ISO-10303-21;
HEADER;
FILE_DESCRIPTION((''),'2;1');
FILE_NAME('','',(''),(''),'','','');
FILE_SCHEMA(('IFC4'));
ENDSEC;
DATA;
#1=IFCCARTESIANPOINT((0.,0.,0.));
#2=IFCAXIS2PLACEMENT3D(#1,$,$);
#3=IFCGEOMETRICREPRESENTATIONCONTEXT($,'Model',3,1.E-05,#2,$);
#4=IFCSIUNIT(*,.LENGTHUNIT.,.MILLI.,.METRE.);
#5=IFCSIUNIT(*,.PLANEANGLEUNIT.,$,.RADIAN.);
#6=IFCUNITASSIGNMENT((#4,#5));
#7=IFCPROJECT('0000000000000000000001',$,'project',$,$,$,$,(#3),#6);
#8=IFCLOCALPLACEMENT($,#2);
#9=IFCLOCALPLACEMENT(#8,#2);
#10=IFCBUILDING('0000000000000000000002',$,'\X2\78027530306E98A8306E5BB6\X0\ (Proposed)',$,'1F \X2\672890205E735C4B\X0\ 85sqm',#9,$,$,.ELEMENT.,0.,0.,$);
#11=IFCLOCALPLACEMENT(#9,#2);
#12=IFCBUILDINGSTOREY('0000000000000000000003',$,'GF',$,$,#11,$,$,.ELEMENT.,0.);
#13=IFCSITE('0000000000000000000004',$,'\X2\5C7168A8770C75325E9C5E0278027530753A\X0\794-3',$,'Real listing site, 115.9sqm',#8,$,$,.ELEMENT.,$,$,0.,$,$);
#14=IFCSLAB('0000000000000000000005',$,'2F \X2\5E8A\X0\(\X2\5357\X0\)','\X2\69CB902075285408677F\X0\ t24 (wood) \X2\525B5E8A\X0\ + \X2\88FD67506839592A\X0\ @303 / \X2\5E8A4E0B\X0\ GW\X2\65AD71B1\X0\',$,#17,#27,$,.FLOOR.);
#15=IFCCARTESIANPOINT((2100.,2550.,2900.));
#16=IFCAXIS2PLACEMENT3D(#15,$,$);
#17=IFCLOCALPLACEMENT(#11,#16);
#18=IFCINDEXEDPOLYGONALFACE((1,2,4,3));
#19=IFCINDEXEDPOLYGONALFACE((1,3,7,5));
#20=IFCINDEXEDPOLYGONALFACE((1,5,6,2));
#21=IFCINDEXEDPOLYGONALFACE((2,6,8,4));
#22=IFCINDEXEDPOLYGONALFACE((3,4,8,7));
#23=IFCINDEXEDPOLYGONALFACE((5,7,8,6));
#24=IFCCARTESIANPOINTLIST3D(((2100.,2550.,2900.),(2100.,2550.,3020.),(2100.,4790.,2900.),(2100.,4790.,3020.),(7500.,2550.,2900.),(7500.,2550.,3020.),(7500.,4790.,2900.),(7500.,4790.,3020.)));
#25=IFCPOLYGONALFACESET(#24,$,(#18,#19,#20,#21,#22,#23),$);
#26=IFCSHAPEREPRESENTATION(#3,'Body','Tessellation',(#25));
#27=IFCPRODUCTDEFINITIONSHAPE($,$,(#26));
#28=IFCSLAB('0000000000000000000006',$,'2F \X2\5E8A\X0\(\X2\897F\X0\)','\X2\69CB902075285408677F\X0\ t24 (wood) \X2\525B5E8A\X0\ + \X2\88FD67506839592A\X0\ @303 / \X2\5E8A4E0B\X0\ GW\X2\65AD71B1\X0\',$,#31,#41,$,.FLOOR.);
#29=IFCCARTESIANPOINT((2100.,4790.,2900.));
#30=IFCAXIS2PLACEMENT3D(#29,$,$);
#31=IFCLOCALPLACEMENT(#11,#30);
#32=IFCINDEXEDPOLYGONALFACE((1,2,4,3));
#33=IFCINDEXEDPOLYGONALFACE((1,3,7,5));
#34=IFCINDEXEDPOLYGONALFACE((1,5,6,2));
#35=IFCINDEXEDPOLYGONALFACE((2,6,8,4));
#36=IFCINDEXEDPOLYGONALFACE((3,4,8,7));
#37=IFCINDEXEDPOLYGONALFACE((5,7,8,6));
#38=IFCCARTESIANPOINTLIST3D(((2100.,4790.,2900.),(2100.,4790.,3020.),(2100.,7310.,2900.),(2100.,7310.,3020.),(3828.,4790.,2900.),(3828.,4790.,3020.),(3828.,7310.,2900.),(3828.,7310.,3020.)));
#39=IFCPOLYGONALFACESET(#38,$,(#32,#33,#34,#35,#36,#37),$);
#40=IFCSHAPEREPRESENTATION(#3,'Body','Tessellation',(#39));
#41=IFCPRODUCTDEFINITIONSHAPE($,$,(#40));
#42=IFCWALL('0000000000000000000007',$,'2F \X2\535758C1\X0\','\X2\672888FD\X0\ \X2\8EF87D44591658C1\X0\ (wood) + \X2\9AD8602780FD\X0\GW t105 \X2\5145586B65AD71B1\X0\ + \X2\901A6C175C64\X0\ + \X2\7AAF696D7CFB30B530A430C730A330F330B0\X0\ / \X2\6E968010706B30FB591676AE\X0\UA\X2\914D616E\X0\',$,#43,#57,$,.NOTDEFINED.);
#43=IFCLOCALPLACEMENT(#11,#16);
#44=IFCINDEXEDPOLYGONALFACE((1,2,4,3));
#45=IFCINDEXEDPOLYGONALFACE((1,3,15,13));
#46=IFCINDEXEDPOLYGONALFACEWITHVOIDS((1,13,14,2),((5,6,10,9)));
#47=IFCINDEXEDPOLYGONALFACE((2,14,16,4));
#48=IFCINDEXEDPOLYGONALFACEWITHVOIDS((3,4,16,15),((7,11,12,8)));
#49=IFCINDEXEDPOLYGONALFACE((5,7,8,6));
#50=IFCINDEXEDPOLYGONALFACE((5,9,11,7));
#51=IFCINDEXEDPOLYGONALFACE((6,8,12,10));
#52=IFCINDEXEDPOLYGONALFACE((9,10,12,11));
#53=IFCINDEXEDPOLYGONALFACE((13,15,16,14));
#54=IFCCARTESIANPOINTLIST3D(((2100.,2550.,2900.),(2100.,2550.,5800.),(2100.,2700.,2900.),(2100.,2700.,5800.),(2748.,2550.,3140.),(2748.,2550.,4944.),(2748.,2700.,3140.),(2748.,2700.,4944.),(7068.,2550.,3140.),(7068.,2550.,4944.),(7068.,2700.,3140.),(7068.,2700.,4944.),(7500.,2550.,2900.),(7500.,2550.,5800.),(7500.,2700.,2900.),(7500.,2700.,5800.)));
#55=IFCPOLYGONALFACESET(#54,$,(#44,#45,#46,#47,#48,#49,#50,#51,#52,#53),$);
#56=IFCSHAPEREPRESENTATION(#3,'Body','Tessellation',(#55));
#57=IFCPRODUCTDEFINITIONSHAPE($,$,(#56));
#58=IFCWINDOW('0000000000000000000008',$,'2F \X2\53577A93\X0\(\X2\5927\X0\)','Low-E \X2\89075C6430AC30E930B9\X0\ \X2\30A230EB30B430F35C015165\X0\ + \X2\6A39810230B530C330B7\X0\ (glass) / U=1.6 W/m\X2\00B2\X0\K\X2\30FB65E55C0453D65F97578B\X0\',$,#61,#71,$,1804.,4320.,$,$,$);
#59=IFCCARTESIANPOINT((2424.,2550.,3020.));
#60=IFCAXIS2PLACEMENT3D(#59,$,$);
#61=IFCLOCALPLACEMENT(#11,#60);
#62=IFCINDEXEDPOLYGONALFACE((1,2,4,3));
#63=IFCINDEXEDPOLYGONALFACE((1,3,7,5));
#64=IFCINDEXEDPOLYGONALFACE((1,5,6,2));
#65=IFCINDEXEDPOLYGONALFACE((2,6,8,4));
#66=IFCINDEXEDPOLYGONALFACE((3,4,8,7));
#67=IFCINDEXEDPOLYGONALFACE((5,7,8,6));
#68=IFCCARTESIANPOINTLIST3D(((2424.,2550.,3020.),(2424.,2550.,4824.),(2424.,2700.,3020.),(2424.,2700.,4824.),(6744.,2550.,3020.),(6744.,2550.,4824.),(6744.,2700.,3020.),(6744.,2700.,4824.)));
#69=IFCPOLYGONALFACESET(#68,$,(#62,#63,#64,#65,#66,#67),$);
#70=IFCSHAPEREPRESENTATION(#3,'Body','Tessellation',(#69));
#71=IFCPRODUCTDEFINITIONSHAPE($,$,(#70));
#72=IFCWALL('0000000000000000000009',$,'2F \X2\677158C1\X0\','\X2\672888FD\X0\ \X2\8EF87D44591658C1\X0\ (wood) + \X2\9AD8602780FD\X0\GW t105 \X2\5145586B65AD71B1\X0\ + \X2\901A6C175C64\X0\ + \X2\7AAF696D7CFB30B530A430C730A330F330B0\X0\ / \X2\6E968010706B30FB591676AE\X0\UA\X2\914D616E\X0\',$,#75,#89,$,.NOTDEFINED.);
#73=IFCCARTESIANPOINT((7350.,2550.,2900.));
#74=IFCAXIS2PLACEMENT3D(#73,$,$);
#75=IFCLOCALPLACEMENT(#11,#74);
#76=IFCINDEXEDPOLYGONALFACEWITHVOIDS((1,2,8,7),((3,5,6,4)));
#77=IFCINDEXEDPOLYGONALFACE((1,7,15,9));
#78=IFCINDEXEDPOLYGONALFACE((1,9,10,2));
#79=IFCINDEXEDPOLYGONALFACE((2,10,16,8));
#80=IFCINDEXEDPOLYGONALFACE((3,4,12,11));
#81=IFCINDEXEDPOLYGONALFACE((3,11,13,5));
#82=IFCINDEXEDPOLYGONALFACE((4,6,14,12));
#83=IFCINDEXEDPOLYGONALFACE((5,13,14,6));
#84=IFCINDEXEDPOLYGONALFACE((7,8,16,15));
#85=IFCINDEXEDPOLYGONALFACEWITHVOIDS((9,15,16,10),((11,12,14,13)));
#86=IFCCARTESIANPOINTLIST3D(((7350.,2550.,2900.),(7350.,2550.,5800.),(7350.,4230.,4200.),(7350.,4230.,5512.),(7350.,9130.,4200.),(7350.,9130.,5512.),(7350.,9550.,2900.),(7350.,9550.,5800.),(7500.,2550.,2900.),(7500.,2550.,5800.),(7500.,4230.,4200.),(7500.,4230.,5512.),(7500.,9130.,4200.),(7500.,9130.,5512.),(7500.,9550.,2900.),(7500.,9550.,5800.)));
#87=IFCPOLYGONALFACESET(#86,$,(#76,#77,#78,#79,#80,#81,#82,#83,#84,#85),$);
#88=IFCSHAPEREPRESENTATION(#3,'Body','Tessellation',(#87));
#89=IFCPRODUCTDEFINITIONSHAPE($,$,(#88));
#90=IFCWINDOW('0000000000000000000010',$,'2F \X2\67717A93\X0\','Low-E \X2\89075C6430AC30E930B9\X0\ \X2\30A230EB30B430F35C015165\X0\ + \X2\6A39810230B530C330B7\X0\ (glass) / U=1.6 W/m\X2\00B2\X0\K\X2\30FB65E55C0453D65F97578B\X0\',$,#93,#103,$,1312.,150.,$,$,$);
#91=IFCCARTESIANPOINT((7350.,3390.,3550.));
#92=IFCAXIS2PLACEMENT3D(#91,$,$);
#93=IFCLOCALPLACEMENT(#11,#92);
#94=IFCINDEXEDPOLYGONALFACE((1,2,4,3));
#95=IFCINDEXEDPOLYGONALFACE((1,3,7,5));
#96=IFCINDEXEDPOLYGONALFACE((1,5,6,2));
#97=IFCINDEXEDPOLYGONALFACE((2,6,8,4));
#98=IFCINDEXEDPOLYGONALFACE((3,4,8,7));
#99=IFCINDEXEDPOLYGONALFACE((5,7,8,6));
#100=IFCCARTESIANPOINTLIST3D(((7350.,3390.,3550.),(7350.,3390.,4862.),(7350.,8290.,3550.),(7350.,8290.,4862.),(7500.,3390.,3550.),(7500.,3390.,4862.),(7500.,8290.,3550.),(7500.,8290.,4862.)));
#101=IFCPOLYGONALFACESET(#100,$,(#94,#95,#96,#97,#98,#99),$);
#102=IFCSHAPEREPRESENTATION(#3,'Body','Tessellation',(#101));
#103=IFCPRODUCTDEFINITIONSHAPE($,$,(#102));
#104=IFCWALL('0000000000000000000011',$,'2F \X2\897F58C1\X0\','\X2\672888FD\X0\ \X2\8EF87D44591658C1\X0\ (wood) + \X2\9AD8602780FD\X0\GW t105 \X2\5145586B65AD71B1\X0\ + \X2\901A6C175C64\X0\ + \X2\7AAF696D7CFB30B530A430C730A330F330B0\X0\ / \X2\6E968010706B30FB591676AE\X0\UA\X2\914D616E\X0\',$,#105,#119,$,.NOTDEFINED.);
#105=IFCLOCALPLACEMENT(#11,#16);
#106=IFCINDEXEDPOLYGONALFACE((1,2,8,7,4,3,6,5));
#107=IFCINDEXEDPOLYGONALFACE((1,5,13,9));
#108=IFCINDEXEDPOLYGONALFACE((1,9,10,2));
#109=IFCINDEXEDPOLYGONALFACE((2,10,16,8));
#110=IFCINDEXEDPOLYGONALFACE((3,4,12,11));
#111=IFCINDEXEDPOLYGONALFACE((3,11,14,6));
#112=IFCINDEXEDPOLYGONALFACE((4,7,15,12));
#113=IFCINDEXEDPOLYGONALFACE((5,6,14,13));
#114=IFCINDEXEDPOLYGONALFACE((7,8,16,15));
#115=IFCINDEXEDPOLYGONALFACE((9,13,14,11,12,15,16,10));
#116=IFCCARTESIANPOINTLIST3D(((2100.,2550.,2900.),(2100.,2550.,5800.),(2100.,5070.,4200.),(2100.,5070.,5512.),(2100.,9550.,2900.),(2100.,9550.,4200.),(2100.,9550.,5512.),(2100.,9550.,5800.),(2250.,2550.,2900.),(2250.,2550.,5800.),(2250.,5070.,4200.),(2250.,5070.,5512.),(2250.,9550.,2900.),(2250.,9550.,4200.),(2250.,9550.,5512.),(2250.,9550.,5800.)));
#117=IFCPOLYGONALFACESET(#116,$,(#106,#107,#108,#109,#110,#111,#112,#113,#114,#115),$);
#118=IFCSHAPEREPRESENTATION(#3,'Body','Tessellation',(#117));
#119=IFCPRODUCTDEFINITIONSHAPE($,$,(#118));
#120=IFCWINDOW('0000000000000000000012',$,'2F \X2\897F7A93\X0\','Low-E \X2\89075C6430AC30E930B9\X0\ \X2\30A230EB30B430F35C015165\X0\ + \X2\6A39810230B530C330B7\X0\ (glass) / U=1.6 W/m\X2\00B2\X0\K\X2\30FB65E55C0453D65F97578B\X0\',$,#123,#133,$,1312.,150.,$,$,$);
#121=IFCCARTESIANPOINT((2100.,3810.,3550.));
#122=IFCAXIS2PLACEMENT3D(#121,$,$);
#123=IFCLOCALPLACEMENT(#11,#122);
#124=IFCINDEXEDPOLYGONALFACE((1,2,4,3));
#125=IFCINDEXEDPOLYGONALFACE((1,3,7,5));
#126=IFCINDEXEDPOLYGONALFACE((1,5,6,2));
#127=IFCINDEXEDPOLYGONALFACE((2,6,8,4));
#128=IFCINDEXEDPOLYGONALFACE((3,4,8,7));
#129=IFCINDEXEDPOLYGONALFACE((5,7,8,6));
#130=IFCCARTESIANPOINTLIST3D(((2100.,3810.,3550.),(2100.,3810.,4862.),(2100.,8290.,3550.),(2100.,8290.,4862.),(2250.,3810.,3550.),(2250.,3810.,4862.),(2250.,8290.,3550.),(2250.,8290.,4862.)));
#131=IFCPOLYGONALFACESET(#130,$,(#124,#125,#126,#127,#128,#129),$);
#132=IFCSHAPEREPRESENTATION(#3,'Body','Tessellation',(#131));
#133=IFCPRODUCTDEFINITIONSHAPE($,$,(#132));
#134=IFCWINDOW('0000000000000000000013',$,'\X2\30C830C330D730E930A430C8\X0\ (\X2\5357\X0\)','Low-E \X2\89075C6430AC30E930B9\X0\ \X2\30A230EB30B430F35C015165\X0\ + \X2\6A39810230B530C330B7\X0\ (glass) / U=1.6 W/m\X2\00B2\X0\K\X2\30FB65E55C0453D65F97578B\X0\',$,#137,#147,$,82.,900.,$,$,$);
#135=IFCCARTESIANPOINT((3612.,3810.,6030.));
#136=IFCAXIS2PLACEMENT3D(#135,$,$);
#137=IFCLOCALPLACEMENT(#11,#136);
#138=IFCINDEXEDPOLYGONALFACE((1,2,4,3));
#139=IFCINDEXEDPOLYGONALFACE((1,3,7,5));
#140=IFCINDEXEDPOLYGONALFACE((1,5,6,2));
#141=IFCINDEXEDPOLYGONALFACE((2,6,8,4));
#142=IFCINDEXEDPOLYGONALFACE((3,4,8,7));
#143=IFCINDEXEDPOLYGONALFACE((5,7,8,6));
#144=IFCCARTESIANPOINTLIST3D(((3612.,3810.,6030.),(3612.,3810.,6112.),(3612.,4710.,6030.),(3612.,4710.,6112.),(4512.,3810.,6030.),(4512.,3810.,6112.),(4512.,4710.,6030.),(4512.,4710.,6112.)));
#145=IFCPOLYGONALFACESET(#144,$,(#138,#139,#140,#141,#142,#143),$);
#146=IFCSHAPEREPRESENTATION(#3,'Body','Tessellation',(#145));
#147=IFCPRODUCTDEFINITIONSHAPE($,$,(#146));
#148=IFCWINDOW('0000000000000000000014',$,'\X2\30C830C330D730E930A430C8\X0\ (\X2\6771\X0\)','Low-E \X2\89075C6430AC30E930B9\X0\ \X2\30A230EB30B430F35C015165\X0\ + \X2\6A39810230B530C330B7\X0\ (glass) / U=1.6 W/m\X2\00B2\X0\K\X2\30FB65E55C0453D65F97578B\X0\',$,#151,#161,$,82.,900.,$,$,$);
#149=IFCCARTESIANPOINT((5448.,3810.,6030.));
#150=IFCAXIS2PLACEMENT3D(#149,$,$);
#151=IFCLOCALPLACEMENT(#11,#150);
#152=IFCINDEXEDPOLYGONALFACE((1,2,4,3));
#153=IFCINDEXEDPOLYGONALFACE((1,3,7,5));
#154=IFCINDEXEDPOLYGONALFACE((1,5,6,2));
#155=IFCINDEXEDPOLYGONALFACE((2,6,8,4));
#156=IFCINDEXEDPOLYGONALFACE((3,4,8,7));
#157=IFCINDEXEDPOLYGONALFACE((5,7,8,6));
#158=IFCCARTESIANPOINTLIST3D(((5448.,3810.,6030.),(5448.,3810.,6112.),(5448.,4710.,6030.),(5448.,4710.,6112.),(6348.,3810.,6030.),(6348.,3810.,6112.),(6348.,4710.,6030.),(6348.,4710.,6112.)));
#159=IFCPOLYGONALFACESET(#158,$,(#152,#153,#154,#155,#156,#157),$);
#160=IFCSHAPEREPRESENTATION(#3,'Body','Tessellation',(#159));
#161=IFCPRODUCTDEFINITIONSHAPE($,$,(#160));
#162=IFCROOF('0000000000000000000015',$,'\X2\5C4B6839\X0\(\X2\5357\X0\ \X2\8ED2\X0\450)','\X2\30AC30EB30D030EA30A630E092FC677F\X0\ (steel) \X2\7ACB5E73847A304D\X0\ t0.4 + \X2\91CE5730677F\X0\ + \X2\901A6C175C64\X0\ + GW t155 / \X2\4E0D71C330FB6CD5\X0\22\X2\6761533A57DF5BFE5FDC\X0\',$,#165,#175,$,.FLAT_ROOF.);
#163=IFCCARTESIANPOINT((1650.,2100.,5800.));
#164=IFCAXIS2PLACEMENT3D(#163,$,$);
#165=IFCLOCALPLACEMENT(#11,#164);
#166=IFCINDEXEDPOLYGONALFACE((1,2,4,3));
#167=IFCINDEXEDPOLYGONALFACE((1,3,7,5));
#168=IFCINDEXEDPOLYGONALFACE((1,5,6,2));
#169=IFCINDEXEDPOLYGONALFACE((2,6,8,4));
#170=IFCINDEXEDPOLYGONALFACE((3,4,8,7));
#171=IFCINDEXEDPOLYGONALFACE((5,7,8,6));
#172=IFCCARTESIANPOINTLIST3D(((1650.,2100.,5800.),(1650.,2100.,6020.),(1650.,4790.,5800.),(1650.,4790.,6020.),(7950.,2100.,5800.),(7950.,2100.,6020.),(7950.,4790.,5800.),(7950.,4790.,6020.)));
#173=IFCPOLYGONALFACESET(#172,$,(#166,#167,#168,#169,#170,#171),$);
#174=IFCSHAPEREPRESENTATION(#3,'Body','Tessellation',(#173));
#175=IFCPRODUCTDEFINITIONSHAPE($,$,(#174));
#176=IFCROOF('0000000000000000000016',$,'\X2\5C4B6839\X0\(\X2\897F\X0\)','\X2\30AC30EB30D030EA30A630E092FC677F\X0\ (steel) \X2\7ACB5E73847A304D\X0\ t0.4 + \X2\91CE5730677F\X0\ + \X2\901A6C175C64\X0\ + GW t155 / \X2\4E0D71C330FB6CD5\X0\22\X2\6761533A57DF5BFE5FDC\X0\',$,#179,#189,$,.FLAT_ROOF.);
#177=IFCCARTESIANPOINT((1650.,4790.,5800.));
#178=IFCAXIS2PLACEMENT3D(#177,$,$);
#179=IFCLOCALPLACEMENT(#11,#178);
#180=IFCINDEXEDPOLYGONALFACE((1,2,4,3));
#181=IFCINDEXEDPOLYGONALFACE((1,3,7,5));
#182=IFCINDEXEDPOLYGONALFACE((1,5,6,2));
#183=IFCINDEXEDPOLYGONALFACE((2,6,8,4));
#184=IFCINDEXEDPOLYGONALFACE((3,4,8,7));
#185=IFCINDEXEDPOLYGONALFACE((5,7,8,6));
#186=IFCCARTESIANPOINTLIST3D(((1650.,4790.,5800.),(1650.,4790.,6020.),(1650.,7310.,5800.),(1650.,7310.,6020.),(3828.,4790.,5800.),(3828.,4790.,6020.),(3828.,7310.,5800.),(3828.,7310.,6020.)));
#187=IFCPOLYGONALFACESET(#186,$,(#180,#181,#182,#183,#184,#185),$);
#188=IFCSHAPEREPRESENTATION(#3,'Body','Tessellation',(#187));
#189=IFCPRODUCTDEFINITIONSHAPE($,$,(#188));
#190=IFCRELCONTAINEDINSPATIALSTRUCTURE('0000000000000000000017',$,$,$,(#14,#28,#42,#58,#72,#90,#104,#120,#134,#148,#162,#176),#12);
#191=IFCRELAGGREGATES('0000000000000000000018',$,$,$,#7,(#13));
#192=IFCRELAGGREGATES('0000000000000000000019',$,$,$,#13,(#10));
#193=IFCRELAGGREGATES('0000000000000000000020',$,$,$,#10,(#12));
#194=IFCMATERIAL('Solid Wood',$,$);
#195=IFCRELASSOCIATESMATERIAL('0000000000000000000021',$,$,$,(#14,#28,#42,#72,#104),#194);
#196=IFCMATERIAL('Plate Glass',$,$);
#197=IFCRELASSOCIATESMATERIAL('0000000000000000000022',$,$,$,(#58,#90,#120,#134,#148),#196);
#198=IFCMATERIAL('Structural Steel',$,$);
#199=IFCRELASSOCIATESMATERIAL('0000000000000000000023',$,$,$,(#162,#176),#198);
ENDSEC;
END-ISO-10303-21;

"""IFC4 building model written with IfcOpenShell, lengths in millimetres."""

from ifc_helpers import new_model, si_unit, frame, frame_2d, origin, place, context, project, spatial, rectangle, extrude, material, element, fill, save


model = new_model("IFC4")

# Units and contexts
model_context = context("Model", 3, precision=1e-05, world=origin())
ifc_project = project(units=[si_unit("LENGTHUNIT", "METRE", prefix="MILLI"), si_unit("PLANEANGLEUNIT", "RADIAN")], contexts=[model_context])

# Site, building, storey
site_placement = place(None, origin())
site = spatial("IfcSite", under=ifc_project, at=site_placement, Name="山梨県甲府市砂田町794-3", ObjectType="Real listing site, 115.9sqm", CompositionType="ELEMENT", RefElevation=0.0)
building_placement = place(site_placement, origin())
building = spatial("IfcBuilding", under=site, at=building_placement, Name="砂田の風の家 (Proposed)", ObjectType="1F 木造平屋 85sqm", CompositionType="ELEMENT", ElevationOfRefHeight=0.0, ElevationOfTerrain=0.0)
storey_placement = place(building_placement, origin())
storey = spatial("IfcBuildingStorey", under=building, at=storey_placement, Name="GF", CompositionType="ELEMENT", Elevation=0.0)

# Slabs
ifc_material_1 = material(Name="Solid Wood")
slab_1_placement = place(storey_placement, frame((2100.0, 2550.0, 2900.0)))
element("IfcSlab", 1, at=slab_1_placement, inside=storey, material=ifc_material_1, Name="2F 床(南)", Description="構造用合板 t24 (wood) 剛床 + 製材根太 @303 / 床下 GW断熱", PredefinedType="FLOOR", context=model_context, shape_type="SweptSolid", body=[
    extrude(rectangle(XDim=5400.0, YDim=2240.0, at=frame_2d((2700.0, 1120.0))), frame((2100.0, 2550.0, 2900.0)), (0.0, 0.0, 1.0), 120.0),
])
slab_2_placement = place(storey_placement, frame((2100.0, 4790.0, 2900.0)))
element("IfcSlab", 2, at=slab_2_placement, inside=storey, material=ifc_material_1, Name="2F 床(西)", Description="構造用合板 t24 (wood) 剛床 + 製材根太 @303 / 床下 GW断熱", PredefinedType="FLOOR", context=model_context, shape_type="SweptSolid", body=[
    extrude(rectangle(XDim=1728.0, YDim=2520.0, at=frame_2d((864.0, 1260.0))), frame((2100.0, 4790.0, 2900.0)), (0.0, 0.0, 1.0), 120.0),
])

# Walls, openings, windows
wall_1_placement = place(storey_placement, frame((2100.0, 2550.0, 2900.0)))
wall_1 = element("IfcWall", 3, at=wall_1_placement, inside=storey, material=ifc_material_1, Name="2F 南壁", Description="木製 軸組外壁 (wood) + 高性能GW t105 充填断熱 + 通気層 + 窯業系サイディング / 準耐火・外皮UA配慮", PredefinedType="NOTDEFINED", context=model_context, shape_type="SweptSolid", body=[
    extrude(rectangle(XDim=5400.0, YDim=150.0, at=frame_2d((2700.0, 75.0))), frame((2100.0, 2550.0, 2900.0)), (0.0, 0.0, 1.0), 2900.0),
])
opening_1_placement = place(storey_placement, frame((2424.0, 2550.0, 3020.0)))
opening_1 = element("IfcOpeningElement", 4, at=opening_1_placement, cuts=wall_1, PredefinedType="NOTDEFINED", context=model_context, shape_type="SweptSolid", body=[
    extrude(rectangle(XDim=4320.0, YDim=150.0, at=frame_2d((2160.0, 75.0))), frame((2424.0, 2550.0, 3020.0)), (0.0, 0.0, 1.0), 1804.0),
])
ifc_material_2 = material(Name="Plate Glass")
window_1_placement = place(storey_placement, frame((2424.0, 2550.0, 3020.0)))
window_1 = element("IfcWindow", 5, at=window_1_placement, inside=storey, material=ifc_material_2, Name="2F 南窓(大)", Description="Low-E 複層ガラス アルゴン封入 + 樹脂サッシ (glass) / U=1.6 W/m²K・日射取得型", OverallHeight=1804.0, OverallWidth=4320.0, context=model_context, shape_type="SweptSolid", body=[
    extrude(rectangle(XDim=4320.0, YDim=150.0, at=frame_2d((2160.0, 75.0))), frame((2424.0, 2550.0, 3020.0)), (0.0, 0.0, 1.0), 1804.0),
])
fill(opening_1, window_1)
wall_2_placement = place(storey_placement, frame((7350.0, 2550.0, 2900.0)))
wall_2 = element("IfcWall", 6, at=wall_2_placement, inside=storey, material=ifc_material_1, Name="2F 東壁", Description="木製 軸組外壁 (wood) + 高性能GW t105 充填断熱 + 通気層 + 窯業系サイディング / 準耐火・外皮UA配慮", PredefinedType="NOTDEFINED", context=model_context, shape_type="SweptSolid", body=[
    extrude(rectangle(XDim=150.0, YDim=7000.0, at=frame_2d((75.0, 3500.0))), frame((7350.0, 2550.0, 2900.0)), (0.0, 0.0, 1.0), 2900.0),
])
opening_2_placement = place(storey_placement, frame((7350.0, 3390.0, 3550.0)))
opening_2 = element("IfcOpeningElement", 7, at=opening_2_placement, cuts=wall_2, PredefinedType="NOTDEFINED", context=model_context, shape_type="SweptSolid", body=[
    extrude(rectangle(XDim=150.0, YDim=4900.0, at=frame_2d((75.0, 2450.0))), frame((7350.0, 3390.0, 3550.0)), (0.0, 0.0, 1.0), 1312.0),
])
window_2_placement = place(storey_placement, frame((7350.0, 3390.0, 3550.0)))
window_2 = element("IfcWindow", 8, at=window_2_placement, inside=storey, material=ifc_material_2, Name="2F 東窓", Description="Low-E 複層ガラス アルゴン封入 + 樹脂サッシ (glass) / U=1.6 W/m²K・日射取得型", OverallHeight=1312.0, OverallWidth=150.0, context=model_context, shape_type="SweptSolid", body=[
    extrude(rectangle(XDim=150.0, YDim=4900.0, at=frame_2d((75.0, 2450.0))), frame((7350.0, 3390.0, 3550.0)), (0.0, 0.0, 1.0), 1312.0),
])
fill(opening_2, window_2)
wall_3_placement = place(storey_placement, frame((2100.0, 2550.0, 2900.0)))
wall_3 = element("IfcWall", 9, at=wall_3_placement, inside=storey, material=ifc_material_1, Name="2F 西壁", Description="木製 軸組外壁 (wood) + 高性能GW t105 充填断熱 + 通気層 + 窯業系サイディング / 準耐火・外皮UA配慮", PredefinedType="NOTDEFINED", context=model_context, shape_type="SweptSolid", body=[
    extrude(rectangle(XDim=150.0, YDim=7000.0, at=frame_2d((75.0, 3500.0))), frame((2100.0, 2550.0, 2900.0)), (0.0, 0.0, 1.0), 2900.0),
])
opening_3_placement = place(storey_placement, frame((2100.0, 3810.0, 3550.0)))
opening_3 = element("IfcOpeningElement", 10, at=opening_3_placement, cuts=wall_3, PredefinedType="NOTDEFINED", context=model_context, shape_type="SweptSolid", body=[
    extrude(rectangle(XDim=150.0, YDim=4480.0, at=frame_2d((75.0, 2240.0))), frame((2100.0, 3810.0, 3550.0)), (0.0, 0.0, 1.0), 1312.0),
])
window_3_placement = place(storey_placement, frame((2100.0, 3810.0, 3550.0)))
window_3 = element("IfcWindow", 11, at=window_3_placement, inside=storey, material=ifc_material_2, Name="2F 西窓", Description="Low-E 複層ガラス アルゴン封入 + 樹脂サッシ (glass) / U=1.6 W/m²K・日射取得型", OverallHeight=1312.0, OverallWidth=150.0, context=model_context, shape_type="SweptSolid", body=[
    extrude(rectangle(XDim=150.0, YDim=4480.0, at=frame_2d((75.0, 2240.0))), frame((2100.0, 3810.0, 3550.0)), (0.0, 0.0, 1.0), 1312.0),
])
fill(opening_3, window_3)

# Windows
window_4_placement = place(storey_placement, frame((3612.0, 3810.0, 6030.0)))
element("IfcWindow", 12, at=window_4_placement, inside=storey, material=ifc_material_2, Name="トップライト (南)", Description="Low-E 複層ガラス アルゴン封入 + 樹脂サッシ (glass) / U=1.6 W/m²K・日射取得型", OverallHeight=82.0, OverallWidth=900.0, context=model_context, shape_type="SweptSolid", body=[
    extrude(rectangle(XDim=900.0, YDim=900.0, at=frame_2d((450.0, 450.0))), frame((3612.0, 3810.0, 6030.0)), (0.0, 0.0, 1.0), 82.0),
])
window_5_placement = place(storey_placement, frame((5448.0, 3810.0, 6030.0)))
element("IfcWindow", 13, at=window_5_placement, inside=storey, material=ifc_material_2, Name="トップライト (東)", Description="Low-E 複層ガラス アルゴン封入 + 樹脂サッシ (glass) / U=1.6 W/m²K・日射取得型", OverallHeight=82.0, OverallWidth=900.0, context=model_context, shape_type="SweptSolid", body=[
    extrude(rectangle(XDim=900.0, YDim=900.0, at=frame_2d((450.0, 450.0))), frame((5448.0, 3810.0, 6030.0)), (0.0, 0.0, 1.0), 82.0),
])

# Roofs
ifc_material_3 = material(Name="Structural Steel")
roof_1_placement = place(storey_placement, frame((1650.0, 2100.0, 5800.0)))
element("IfcRoof", 14, at=roof_1_placement, inside=storey, material=ifc_material_3, Name="屋根(南 軒450)", Description="ガルバリウム鋼板 (steel) 立平葺き t0.4 + 野地板 + 通気層 + GW t155 / 不燃・法22条区域対応", PredefinedType="FLAT_ROOF", context=model_context, shape_type="SweptSolid", body=[
    extrude(rectangle(XDim=6300.0, YDim=2690.0, at=frame_2d((3150.0, 1345.0))), frame((1650.0, 2100.0, 5800.0)), (0.0, 0.0, 1.0), 220.0),
])
roof_2_placement = place(storey_placement, frame((1650.0, 4790.0, 5800.0)))
element("IfcRoof", 15, at=roof_2_placement, inside=storey, material=ifc_material_3, Name="屋根(西)", Description="ガルバリウム鋼板 (steel) 立平葺き t0.4 + 野地板 + 通気層 + GW t155 / 不燃・法22条区域対応", PredefinedType="FLAT_ROOF", context=model_context, shape_type="SweptSolid", body=[
    extrude(rectangle(XDim=2178.0, YDim=2520.0, at=frame_2d((1089.0, 1260.0))), frame((1650.0, 4790.0, 5800.0)), (0.0, 0.0, 1.0), 220.0),
])

save(model, "model.ifc")
